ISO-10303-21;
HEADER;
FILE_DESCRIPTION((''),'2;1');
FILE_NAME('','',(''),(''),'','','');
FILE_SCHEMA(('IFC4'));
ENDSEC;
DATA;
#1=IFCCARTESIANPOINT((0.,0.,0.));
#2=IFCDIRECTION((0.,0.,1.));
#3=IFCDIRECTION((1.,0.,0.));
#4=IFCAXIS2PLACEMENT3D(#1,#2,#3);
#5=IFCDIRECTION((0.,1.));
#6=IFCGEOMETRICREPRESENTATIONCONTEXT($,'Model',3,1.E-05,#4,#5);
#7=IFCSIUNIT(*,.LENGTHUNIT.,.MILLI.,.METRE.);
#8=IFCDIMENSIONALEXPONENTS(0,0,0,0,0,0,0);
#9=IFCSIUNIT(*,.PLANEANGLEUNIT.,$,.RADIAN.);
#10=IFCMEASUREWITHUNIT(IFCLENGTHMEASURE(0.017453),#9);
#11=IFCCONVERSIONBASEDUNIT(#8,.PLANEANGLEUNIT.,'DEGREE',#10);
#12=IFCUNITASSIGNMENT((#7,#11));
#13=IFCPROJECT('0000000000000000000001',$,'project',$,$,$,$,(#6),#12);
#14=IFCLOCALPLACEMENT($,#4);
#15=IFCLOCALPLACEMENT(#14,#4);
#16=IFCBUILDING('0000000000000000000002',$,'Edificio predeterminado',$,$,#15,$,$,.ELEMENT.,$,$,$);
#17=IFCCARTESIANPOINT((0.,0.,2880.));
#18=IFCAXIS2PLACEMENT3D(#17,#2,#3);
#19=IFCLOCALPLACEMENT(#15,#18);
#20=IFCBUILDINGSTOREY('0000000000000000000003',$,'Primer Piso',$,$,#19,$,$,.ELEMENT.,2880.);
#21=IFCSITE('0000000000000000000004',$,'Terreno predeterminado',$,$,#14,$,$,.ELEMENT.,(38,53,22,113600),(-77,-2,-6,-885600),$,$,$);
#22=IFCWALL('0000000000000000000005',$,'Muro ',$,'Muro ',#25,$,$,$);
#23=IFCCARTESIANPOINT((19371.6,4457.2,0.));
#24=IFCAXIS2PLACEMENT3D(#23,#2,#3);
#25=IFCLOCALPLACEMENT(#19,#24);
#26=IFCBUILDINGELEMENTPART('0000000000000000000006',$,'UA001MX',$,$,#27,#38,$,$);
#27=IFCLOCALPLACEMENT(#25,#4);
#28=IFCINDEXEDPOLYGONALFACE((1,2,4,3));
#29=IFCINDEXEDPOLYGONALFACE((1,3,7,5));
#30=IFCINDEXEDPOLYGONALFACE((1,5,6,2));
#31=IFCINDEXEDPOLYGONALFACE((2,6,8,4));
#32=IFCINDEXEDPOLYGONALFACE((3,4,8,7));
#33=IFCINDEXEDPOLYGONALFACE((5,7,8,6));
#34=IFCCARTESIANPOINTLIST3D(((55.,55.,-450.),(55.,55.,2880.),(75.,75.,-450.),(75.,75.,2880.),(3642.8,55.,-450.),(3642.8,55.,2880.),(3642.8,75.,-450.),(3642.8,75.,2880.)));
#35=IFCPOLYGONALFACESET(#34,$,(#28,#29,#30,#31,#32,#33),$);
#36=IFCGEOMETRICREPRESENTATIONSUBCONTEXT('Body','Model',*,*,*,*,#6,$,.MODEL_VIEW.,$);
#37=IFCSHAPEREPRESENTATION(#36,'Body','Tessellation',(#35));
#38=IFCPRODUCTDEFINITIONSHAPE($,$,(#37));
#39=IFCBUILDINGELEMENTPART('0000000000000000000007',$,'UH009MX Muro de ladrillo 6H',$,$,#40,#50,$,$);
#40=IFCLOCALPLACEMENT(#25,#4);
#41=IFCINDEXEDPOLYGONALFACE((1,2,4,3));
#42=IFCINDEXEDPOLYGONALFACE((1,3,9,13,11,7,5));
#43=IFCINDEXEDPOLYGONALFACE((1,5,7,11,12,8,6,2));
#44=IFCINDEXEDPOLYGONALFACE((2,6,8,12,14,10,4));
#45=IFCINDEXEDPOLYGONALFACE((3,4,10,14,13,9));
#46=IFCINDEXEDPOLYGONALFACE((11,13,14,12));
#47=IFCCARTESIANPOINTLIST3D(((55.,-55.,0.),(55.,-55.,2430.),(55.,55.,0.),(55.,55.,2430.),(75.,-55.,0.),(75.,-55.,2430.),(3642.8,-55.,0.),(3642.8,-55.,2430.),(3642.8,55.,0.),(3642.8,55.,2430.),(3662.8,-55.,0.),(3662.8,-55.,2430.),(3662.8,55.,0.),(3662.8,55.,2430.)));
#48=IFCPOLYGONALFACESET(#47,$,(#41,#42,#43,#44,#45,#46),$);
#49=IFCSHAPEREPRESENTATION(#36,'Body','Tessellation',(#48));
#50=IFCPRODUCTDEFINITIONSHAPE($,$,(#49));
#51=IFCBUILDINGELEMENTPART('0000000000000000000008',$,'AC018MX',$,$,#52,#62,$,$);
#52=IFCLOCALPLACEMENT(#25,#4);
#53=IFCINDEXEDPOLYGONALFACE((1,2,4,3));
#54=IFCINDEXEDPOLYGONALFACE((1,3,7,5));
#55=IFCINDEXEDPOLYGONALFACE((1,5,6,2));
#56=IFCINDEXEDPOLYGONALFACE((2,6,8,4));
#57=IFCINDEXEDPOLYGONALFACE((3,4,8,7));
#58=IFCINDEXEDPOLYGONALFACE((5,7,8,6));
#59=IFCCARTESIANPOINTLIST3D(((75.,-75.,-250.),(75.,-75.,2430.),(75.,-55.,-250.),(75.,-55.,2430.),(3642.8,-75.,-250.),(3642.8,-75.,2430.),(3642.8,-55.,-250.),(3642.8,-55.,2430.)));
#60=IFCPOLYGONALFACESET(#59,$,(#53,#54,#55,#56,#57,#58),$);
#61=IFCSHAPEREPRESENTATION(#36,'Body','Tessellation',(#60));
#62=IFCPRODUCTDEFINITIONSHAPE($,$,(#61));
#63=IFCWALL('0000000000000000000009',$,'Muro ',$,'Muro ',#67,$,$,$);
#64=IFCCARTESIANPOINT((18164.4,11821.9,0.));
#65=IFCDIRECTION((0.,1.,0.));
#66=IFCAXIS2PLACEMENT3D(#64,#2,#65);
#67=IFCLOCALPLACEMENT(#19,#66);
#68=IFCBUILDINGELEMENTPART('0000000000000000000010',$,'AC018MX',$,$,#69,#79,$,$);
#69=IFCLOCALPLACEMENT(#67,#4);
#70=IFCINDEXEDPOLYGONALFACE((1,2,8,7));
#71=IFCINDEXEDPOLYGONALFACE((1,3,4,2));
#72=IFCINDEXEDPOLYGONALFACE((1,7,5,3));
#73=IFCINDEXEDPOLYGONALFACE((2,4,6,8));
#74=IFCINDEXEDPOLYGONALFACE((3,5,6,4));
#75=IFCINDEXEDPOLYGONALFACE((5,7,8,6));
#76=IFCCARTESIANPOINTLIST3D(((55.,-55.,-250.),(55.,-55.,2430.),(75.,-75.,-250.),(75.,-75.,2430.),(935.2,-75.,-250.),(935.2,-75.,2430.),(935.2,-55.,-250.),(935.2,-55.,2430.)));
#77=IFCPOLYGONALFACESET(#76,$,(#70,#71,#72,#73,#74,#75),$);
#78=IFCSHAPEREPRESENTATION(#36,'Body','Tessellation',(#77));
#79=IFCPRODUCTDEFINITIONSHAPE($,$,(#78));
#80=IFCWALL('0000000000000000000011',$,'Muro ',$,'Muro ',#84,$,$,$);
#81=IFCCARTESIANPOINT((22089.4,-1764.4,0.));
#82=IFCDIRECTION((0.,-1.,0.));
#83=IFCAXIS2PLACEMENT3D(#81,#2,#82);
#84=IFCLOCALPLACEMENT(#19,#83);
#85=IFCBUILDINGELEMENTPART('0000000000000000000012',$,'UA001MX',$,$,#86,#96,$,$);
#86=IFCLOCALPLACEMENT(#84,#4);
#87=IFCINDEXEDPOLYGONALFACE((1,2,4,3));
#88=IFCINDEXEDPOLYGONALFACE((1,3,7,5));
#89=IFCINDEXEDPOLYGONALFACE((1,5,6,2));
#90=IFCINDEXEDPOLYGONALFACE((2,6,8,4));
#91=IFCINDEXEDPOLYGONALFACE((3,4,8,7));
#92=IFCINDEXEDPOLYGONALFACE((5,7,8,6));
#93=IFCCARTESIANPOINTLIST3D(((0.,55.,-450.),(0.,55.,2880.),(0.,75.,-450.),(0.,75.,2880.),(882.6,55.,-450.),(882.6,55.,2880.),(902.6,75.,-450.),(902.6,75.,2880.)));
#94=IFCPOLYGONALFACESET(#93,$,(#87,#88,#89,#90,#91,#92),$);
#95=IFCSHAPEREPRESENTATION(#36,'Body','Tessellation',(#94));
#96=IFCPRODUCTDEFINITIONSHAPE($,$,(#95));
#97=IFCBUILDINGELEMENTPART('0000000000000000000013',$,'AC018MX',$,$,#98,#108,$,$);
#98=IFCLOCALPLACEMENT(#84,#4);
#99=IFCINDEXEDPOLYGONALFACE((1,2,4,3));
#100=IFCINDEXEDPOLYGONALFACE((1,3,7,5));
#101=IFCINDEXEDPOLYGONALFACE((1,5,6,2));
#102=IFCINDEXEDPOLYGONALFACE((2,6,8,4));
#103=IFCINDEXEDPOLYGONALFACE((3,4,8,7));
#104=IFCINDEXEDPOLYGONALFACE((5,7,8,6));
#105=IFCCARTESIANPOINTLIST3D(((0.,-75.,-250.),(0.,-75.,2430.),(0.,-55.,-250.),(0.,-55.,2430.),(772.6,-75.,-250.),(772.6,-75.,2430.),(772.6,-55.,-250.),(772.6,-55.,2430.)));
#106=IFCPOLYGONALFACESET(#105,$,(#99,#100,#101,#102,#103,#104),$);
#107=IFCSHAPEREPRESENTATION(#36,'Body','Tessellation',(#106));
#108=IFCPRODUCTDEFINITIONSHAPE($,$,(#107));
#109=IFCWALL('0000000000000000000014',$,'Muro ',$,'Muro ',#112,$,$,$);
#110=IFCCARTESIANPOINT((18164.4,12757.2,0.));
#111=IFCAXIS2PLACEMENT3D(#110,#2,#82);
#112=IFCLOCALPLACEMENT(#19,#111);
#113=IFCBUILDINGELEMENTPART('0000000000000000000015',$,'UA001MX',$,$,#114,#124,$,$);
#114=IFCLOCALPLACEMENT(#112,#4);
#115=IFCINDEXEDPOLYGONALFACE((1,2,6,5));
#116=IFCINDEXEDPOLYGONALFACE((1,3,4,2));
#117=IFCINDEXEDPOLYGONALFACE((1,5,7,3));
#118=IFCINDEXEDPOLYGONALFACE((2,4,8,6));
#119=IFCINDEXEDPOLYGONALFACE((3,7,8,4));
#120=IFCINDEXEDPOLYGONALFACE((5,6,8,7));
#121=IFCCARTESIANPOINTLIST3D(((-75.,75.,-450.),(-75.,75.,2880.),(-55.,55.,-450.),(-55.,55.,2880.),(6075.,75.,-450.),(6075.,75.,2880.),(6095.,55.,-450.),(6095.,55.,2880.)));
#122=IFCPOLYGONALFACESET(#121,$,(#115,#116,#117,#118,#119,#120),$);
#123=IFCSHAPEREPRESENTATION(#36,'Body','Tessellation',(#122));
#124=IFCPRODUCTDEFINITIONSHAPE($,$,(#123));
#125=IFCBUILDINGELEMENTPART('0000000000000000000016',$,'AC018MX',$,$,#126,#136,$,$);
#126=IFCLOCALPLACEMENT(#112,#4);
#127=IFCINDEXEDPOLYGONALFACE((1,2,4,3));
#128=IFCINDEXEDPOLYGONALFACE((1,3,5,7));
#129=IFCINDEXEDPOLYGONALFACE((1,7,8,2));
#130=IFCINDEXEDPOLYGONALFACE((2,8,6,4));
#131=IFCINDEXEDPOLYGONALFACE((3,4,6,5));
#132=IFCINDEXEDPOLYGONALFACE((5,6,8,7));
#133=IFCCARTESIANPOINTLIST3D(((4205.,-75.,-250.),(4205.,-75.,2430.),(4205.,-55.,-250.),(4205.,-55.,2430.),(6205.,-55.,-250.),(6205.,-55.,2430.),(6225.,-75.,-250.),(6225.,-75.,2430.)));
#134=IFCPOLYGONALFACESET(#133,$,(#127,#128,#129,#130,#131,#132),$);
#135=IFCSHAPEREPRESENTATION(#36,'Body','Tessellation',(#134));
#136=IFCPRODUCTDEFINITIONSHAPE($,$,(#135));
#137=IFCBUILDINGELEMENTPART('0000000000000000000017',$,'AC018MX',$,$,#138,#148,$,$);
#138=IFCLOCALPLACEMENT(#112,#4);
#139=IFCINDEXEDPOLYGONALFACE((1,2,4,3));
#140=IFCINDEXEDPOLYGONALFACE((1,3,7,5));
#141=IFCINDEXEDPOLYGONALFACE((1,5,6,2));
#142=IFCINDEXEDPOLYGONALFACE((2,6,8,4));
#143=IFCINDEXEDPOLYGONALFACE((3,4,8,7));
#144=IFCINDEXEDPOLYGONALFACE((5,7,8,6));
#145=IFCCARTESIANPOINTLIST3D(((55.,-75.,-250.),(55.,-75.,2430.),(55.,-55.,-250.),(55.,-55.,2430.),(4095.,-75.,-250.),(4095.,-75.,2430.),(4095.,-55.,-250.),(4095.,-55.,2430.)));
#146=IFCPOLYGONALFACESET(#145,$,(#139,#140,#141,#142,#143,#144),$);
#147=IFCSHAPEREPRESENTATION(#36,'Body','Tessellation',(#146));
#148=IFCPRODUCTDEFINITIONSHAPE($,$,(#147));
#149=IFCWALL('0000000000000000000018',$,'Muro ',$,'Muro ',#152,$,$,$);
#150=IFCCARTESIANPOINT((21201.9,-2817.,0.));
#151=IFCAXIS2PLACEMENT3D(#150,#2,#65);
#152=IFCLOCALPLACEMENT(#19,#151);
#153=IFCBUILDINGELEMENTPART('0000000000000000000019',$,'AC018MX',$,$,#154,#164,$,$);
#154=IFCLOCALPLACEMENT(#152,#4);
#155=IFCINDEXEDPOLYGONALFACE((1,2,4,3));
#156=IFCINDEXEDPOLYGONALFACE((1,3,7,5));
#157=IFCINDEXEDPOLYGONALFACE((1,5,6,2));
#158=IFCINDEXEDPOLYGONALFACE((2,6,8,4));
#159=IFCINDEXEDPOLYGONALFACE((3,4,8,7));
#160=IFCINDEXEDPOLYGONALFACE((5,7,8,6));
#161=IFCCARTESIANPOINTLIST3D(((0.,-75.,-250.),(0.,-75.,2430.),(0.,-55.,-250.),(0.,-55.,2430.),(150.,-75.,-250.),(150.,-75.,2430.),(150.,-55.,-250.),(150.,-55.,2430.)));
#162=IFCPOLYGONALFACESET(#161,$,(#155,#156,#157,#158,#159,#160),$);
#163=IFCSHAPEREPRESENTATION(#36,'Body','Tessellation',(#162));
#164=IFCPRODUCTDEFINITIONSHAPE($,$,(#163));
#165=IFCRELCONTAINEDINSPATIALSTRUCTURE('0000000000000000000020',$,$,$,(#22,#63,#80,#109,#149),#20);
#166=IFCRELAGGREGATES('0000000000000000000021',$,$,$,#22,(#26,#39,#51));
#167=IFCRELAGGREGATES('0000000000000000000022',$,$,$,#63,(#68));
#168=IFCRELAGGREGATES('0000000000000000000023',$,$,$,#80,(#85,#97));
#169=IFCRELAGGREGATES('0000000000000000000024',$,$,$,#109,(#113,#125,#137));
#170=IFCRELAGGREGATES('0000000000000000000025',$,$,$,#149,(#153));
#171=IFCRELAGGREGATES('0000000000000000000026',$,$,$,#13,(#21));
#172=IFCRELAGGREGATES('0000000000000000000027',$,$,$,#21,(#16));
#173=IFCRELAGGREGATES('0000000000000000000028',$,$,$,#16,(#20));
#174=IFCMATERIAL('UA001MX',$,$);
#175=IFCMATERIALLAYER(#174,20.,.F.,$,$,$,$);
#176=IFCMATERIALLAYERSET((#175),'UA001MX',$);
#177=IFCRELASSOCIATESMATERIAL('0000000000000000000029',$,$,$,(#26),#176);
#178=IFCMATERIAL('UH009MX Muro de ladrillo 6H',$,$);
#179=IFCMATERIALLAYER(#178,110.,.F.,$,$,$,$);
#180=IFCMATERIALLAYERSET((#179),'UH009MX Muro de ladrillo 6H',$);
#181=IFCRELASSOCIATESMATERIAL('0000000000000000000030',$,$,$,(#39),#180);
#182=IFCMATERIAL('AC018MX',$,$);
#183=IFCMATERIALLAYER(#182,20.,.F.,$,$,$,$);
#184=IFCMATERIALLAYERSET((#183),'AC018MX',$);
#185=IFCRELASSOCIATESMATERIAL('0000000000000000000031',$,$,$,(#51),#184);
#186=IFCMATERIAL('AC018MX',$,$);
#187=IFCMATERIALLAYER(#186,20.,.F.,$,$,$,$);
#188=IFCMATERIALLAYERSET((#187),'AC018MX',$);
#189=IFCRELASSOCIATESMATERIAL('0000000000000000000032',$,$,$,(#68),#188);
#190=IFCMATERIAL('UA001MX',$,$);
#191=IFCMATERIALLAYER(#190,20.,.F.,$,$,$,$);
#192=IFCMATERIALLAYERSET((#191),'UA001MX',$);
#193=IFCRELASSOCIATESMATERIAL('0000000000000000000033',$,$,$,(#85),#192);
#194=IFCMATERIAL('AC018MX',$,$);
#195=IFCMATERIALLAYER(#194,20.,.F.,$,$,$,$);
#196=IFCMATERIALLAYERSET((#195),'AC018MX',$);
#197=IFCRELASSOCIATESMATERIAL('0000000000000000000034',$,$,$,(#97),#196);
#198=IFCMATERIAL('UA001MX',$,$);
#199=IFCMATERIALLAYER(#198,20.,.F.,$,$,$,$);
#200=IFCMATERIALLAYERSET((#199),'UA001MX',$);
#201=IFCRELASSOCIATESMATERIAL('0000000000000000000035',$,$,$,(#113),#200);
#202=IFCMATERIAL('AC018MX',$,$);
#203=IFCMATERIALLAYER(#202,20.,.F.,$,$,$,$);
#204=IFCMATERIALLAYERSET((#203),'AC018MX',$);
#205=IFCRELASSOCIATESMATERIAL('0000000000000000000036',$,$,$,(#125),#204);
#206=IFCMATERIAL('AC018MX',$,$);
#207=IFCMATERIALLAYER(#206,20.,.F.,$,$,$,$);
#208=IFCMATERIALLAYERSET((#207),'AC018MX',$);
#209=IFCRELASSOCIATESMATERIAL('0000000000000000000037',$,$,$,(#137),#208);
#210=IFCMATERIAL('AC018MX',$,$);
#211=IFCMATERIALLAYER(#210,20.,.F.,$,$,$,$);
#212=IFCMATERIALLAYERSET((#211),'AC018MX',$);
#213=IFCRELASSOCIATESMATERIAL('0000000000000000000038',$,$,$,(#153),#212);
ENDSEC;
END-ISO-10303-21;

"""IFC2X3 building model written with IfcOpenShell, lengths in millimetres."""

from ifc_helpers import new_model, entity, si_unit, converted_unit, direction, frame, origin_with_axes, place, context, subcontext, project, spatial, polyline, outline, extrude, clip, bounded_halfspace, material, layer, layer_set, layer_usage, element, aggregate, save


model = new_model("IFC2X3")

# Units and contexts
model_context = context("Model", 3, precision=1e-05, world=origin_with_axes(), true_north=direction((0.0, 1.0)))
body_context = subcontext(model_context, "Body", "Model", "MODEL_VIEW")
ifc_project = project(units=[si_unit("LENGTHUNIT", "METRE", prefix="MILLI"), converted_unit("PLANEANGLEUNIT", "DEGREE", entity("IfcLengthMeasure", 0.017453), si_unit("PLANEANGLEUNIT", "RADIAN"), dimensions=[0, 0, 0, 0, 0, 0, 0])], contexts=[model_context])

# Site, building, storey
site_placement = place(None, origin_with_axes())
site = spatial("IfcSite", under=ifc_project, at=site_placement, Name="Terreno predeterminado", CompositionType="ELEMENT", RefLatitude=(38, 53, 22, 113600), RefLongitude=(-77, -2, -6, -885600))
building_placement = place(site_placement, origin_with_axes())
building = spatial("IfcBuilding", under=site, at=building_placement, Name="Edificio predeterminado", CompositionType="ELEMENT")
storey_placement = place(building_placement, frame((0.0, 0.0, 2880.0), z_axis=(0.0, 0.0, 1.0), x_axis=(1.0, 0.0, 0.0)))
storey = spatial("IfcBuildingStorey", under=building, at=storey_placement, Name="Primer Piso", CompositionType="ELEMENT", Elevation=2880.0)

# Walls, building element parts
wall_1_placement = place(storey_placement, frame((19371.6, 4457.2, 0.0), z_axis=(0.0, 0.0, 1.0), x_axis=(1.0, 0.0, 0.0)))
wall_1 = element("IfcWall", 1, at=wall_1_placement, inside=storey, Name="Muro ", ObjectType="Muro ")
ifc_material_1 = material(Name="UA001MX")
ifc_layer_1 = layer(ifc_material_1, 20.0, ventilated=False)
ifc_layer_set_1 = layer_set([ifc_layer_1], Name="UA001MX")
ifc_layer_usage_1 = layer_usage(ifc_layer_set_1, "AXIS2", "NEGATIVE", -75.0)
building_element_part_1_placement = place(wall_1_placement, origin_with_axes())
building_element_part_1 = element("IfcBuildingElementPart", 2, at=building_element_part_1_placement, material=ifc_layer_usage_1, Name="UA001MX", context=body_context, shape_type="SweptSolid", body=[
    extrude(outline(polyline([(3642.8, 75.0), (3642.8, 55.0), (55.0, 55.0), (75.0, 75.0), (3642.8, 75.0)])), frame((0.0, 0.0, -450.0), z_axis=(0.0, 0.0, 1.0), x_axis=(1.0, 0.0, 0.0)), (0.0, 0.0, 1.0), 3330.0),
])
ifc_material_2 = material(Name="UH009MX Muro de ladrillo 6H")
ifc_layer_2 = layer(ifc_material_2, 110.0, ventilated=False)
ifc_layer_set_2 = layer_set([ifc_layer_2], Name="UH009MX Muro de ladrillo 6H")
ifc_layer_usage_2 = layer_usage(ifc_layer_set_2, "AXIS2", "NEGATIVE", -55.0)
building_element_part_2_placement = place(wall_1_placement, origin_with_axes())
building_element_part_2 = element("IfcBuildingElementPart", 3, at=building_element_part_2_placement, material=ifc_layer_usage_2, Name="UH009MX Muro de ladrillo 6H", context=body_context, shape_type="SweptSolid", body=[
    extrude(outline(polyline([(3662.8, 55.0), (3662.8, -55.0), (3642.8, -55.0), (75.0, -55.0), (55.0, -55.0), (55.0, 55.0), (3642.8, 55.0), (3662.8, 55.0)])), origin_with_axes(), (0.0, 0.0, 1.0), 2430.0),
])
ifc_material_3 = material(Name="AC018MX")
ifc_layer_3 = layer(ifc_material_3, 20.0, ventilated=False)
ifc_layer_set_3 = layer_set([ifc_layer_3], Name="AC018MX")
ifc_layer_usage_3 = layer_usage(ifc_layer_set_3, "AXIS2", "NEGATIVE", 55.0)
building_element_part_3_placement = place(wall_1_placement, origin_with_axes())
building_element_part_3 = element("IfcBuildingElementPart", 4, at=building_element_part_3_placement, material=ifc_layer_usage_3, Name="AC018MX", context=body_context, shape_type="SweptSolid", body=[
    extrude(outline(polyline([(3642.8, -55.0), (3642.8, -75.0), (75.0, -75.0), (75.0, -55.0), (3642.8, -55.0)])), frame((0.0, 0.0, -250.0), z_axis=(0.0, 0.0, 1.0), x_axis=(1.0, 0.0, 0.0)), (0.0, 0.0, 1.0), 2680.0),
])
aggregate(wall_1, [building_element_part_1, building_element_part_2, building_element_part_3])
wall_2_placement = place(storey_placement, frame((18164.4, 11821.9, 0.0), z_axis=(0.0, 0.0, 1.0), x_axis=(0.0, 1.0, 0.0)))
wall_2 = element("IfcWall", 5, at=wall_2_placement, inside=storey, Name="Muro ", ObjectType="Muro ")
ifc_material_4 = material(Name="AC018MX")
ifc_layer_4 = layer(ifc_material_4, 20.0, ventilated=False)
ifc_layer_set_4 = layer_set([ifc_layer_4], Name="AC018MX")
ifc_layer_usage_4 = layer_usage(ifc_layer_set_4, "AXIS2", "NEGATIVE", 55.0)
building_element_part_4_placement = place(wall_2_placement, origin_with_axes())
building_element_part_4 = element("IfcBuildingElementPart", 6, at=building_element_part_4_placement, material=ifc_layer_usage_4, Name="AC018MX", context=body_context, shape_type="SweptSolid", body=[
    extrude(outline(polyline([(935.2, -55.0), (935.2, -75.0), (75.0, -75.0), (55.0, -55.0), (935.2, -55.0)])), frame((0.0, 0.0, -250.0), z_axis=(0.0, 0.0, 1.0), x_axis=(1.0, 0.0, 0.0)), (0.0, 0.0, 1.0), 2680.0),
])
aggregate(wall_2, [building_element_part_4])
wall_3_placement = place(storey_placement, frame((22089.4, -1764.4, 0.0), z_axis=(0.0, 0.0, 1.0), x_axis=(0.0, -1.0, 0.0)))
wall_3 = element("IfcWall", 7, at=wall_3_placement, inside=storey, Name="Muro ", ObjectType="Muro ")
ifc_material_5 = material(Name="UA001MX")
ifc_layer_5 = layer(ifc_material_5, 20.0, ventilated=False)
ifc_layer_set_5 = layer_set([ifc_layer_5], Name="UA001MX")
ifc_layer_usage_5 = layer_usage(ifc_layer_set_5, "AXIS2", "NEGATIVE", -75.0)
building_element_part_5_placement = place(wall_3_placement, origin_with_axes())
building_element_part_5 = element("IfcBuildingElementPart", 8, at=building_element_part_5_placement, material=ifc_layer_usage_5, Name="UA001MX", context=body_context, shape_type="SweptSolid", body=[
    extrude(outline(polyline([(902.6, 75.0), (882.6, 55.0), (0.0, 55.0), (0.0, 75.0), (902.6, 75.0)])), frame((0.0, 0.0, -450.0), z_axis=(0.0, 0.0, 1.0), x_axis=(1.0, 0.0, 0.0)), (0.0, 0.0, 1.0), 3330.0),
])
ifc_material_6 = material(Name="AC018MX")
ifc_layer_6 = layer(ifc_material_6, 20.0, ventilated=False)
ifc_layer_set_6 = layer_set([ifc_layer_6], Name="AC018MX")
ifc_layer_usage_6 = layer_usage(ifc_layer_set_6, "AXIS2", "NEGATIVE", 55.0)
building_element_part_6_placement = place(wall_3_placement, origin_with_axes())
building_element_part_6 = element("IfcBuildingElementPart", 9, at=building_element_part_6_placement, material=ifc_layer_usage_6, Name="AC018MX", context=body_context, shape_type="SweptSolid", body=[
    extrude(outline(polyline([(772.6, -55.0), (772.6, -75.0), (0.0, -75.0), (0.0, -55.0), (772.6, -55.0)])), frame((0.0, 0.0, -250.0), z_axis=(0.0, 0.0, 1.0), x_axis=(1.0, 0.0, 0.0)), (0.0, 0.0, 1.0), 2680.0),
])
aggregate(wall_3, [building_element_part_5, building_element_part_6])
wall_4_placement = place(storey_placement, frame((18164.4, 12757.2, 0.0), z_axis=(0.0, 0.0, 1.0), x_axis=(0.0, -1.0, 0.0)))
wall_4 = element("IfcWall", 10, at=wall_4_placement, inside=storey, Name="Muro ", ObjectType="Muro ")
ifc_material_7 = material(Name="UA001MX")
ifc_layer_7 = layer(ifc_material_7, 20.0, ventilated=False)
ifc_layer_set_7 = layer_set([ifc_layer_7], Name="UA001MX")
ifc_layer_usage_7 = layer_usage(ifc_layer_set_7, "AXIS2", "NEGATIVE", -75.0)
building_element_part_7_placement = place(wall_4_placement, origin_with_axes())
building_element_part_7 = element("IfcBuildingElementPart", 11, at=building_element_part_7_placement, material=ifc_layer_usage_7, Name="UA001MX", context=body_context, shape_type="SweptSolid", body=[
    extrude(outline(polyline([(6075.0, 75.0), (6095.0, 55.0), (-55.0, 55.0), (-75.0, 75.0), (6075.0, 75.0)])), frame((0.0, 0.0, -450.0), z_axis=(0.0, 0.0, 1.0), x_axis=(1.0, 0.0, 0.0)), (0.0, 0.0, 1.0), 3330.0),
])
ifc_material_8 = material(Name="AC018MX")
ifc_layer_8 = layer(ifc_material_8, 20.0, ventilated=False)
ifc_layer_set_8 = layer_set([ifc_layer_8], Name="AC018MX")
ifc_layer_usage_8 = layer_usage(ifc_layer_set_8, "AXIS2", "NEGATIVE", 55.0)
building_element_part_8_placement = place(wall_4_placement, origin_with_axes())
building_element_part_8 = element("IfcBuildingElementPart", 12, at=building_element_part_8_placement, material=ifc_layer_usage_8, Name="AC018MX", context=body_context, shape_type="SweptSolid", body=[
    extrude(outline(polyline([(6205.0, -55.0), (6225.0, -75.0), (4205.0, -75.0), (4205.0, -55.0), (6205.0, -55.0)])), frame((0.0, 0.0, -250.0), z_axis=(0.0, 0.0, 1.0), x_axis=(1.0, 0.0, 0.0)), (0.0, 0.0, 1.0), 2680.0),
])
ifc_material_9 = material(Name="AC018MX")
ifc_layer_9 = layer(ifc_material_9, 20.0, ventilated=False)
ifc_layer_set_9 = layer_set([ifc_layer_9], Name="AC018MX")
ifc_layer_usage_9 = layer_usage(ifc_layer_set_9, "AXIS2", "NEGATIVE", 55.0)
building_element_part_9_placement = place(wall_4_placement, origin_with_axes())
building_element_part_9 = element("IfcBuildingElementPart", 13, at=building_element_part_9_placement, material=ifc_layer_usage_9, Name="AC018MX", context=body_context, shape_type="SweptSolid", body=[
    extrude(outline(polyline([(4095.0, -55.0), (4095.0, -75.0), (55.0, -75.0), (55.0, -55.0), (4095.0, -55.0)])), frame((0.0, 0.0, -250.0), z_axis=(0.0, 0.0, 1.0), x_axis=(1.0, 0.0, 0.0)), (0.0, 0.0, 1.0), 2680.0),
])
aggregate(wall_4, [building_element_part_7, building_element_part_8, building_element_part_9])
wall_5_placement = place(storey_placement, frame((21201.9, -2817.0, 0.0), z_axis=(0.0, 0.0, 1.0), x_axis=(0.0, 1.0, 0.0)))
wall_5 = element("IfcWall", 14, at=wall_5_placement, inside=storey, Name="Muro ", ObjectType="Muro ")
ifc_material_10 = material(Name="AC018MX")
ifc_layer_10 = layer(ifc_material_10, 20.0, ventilated=False)
ifc_layer_set_10 = layer_set([ifc_layer_10], Name="AC018MX")
ifc_layer_usage_10 = layer_usage(ifc_layer_set_10, "AXIS2", "NEGATIVE", 55.0)
building_element_part_10_placement = place(wall_5_placement, origin_with_axes())
building_element_part_10 = element("IfcBuildingElementPart", 15, at=building_element_part_10_placement, material=ifc_layer_usage_10, Name="AC018MX", context=body_context, shape_type="Clipping", body=[
    clip(clip(extrude(outline(polyline([(150.0, -55.0), (150.0, -75.0), (0.0, -75.0), (0.0, -55.0), (150.0, -55.0)])), frame((0.0, 0.0, -250.0), z_axis=(0.0, 0.0, 1.0), x_axis=(1.0, 0.0, 0.0)), (0.0, 0.0, 1.0), 2680.0), bounded_halfspace(frame((0.0, 0.0, -250.0), z_axis=(0.0, 0.0, 1.0), x_axis=(1.0, 0.0, 0.0)), True, origin_with_axes(), polyline([(-150.0, -150.0), (375.0, -150.0), (375.0, 150.0), (-150.0, 150.0), (-150.0, -150.0)]))), bounded_halfspace(frame((0.0, 0.0, 2430.0), z_axis=(0.0, 0.0, 1.0), x_axis=(1.0, 0.0, 0.0)), False, origin_with_axes(), polyline([(-150.0, -150.0), (375.0, -150.0), (375.0, 150.0), (-150.0, 150.0), (-150.0, -150.0)]))),
])
aggregate(wall_5, [building_element_part_10])

save(model, "model.ifc")
